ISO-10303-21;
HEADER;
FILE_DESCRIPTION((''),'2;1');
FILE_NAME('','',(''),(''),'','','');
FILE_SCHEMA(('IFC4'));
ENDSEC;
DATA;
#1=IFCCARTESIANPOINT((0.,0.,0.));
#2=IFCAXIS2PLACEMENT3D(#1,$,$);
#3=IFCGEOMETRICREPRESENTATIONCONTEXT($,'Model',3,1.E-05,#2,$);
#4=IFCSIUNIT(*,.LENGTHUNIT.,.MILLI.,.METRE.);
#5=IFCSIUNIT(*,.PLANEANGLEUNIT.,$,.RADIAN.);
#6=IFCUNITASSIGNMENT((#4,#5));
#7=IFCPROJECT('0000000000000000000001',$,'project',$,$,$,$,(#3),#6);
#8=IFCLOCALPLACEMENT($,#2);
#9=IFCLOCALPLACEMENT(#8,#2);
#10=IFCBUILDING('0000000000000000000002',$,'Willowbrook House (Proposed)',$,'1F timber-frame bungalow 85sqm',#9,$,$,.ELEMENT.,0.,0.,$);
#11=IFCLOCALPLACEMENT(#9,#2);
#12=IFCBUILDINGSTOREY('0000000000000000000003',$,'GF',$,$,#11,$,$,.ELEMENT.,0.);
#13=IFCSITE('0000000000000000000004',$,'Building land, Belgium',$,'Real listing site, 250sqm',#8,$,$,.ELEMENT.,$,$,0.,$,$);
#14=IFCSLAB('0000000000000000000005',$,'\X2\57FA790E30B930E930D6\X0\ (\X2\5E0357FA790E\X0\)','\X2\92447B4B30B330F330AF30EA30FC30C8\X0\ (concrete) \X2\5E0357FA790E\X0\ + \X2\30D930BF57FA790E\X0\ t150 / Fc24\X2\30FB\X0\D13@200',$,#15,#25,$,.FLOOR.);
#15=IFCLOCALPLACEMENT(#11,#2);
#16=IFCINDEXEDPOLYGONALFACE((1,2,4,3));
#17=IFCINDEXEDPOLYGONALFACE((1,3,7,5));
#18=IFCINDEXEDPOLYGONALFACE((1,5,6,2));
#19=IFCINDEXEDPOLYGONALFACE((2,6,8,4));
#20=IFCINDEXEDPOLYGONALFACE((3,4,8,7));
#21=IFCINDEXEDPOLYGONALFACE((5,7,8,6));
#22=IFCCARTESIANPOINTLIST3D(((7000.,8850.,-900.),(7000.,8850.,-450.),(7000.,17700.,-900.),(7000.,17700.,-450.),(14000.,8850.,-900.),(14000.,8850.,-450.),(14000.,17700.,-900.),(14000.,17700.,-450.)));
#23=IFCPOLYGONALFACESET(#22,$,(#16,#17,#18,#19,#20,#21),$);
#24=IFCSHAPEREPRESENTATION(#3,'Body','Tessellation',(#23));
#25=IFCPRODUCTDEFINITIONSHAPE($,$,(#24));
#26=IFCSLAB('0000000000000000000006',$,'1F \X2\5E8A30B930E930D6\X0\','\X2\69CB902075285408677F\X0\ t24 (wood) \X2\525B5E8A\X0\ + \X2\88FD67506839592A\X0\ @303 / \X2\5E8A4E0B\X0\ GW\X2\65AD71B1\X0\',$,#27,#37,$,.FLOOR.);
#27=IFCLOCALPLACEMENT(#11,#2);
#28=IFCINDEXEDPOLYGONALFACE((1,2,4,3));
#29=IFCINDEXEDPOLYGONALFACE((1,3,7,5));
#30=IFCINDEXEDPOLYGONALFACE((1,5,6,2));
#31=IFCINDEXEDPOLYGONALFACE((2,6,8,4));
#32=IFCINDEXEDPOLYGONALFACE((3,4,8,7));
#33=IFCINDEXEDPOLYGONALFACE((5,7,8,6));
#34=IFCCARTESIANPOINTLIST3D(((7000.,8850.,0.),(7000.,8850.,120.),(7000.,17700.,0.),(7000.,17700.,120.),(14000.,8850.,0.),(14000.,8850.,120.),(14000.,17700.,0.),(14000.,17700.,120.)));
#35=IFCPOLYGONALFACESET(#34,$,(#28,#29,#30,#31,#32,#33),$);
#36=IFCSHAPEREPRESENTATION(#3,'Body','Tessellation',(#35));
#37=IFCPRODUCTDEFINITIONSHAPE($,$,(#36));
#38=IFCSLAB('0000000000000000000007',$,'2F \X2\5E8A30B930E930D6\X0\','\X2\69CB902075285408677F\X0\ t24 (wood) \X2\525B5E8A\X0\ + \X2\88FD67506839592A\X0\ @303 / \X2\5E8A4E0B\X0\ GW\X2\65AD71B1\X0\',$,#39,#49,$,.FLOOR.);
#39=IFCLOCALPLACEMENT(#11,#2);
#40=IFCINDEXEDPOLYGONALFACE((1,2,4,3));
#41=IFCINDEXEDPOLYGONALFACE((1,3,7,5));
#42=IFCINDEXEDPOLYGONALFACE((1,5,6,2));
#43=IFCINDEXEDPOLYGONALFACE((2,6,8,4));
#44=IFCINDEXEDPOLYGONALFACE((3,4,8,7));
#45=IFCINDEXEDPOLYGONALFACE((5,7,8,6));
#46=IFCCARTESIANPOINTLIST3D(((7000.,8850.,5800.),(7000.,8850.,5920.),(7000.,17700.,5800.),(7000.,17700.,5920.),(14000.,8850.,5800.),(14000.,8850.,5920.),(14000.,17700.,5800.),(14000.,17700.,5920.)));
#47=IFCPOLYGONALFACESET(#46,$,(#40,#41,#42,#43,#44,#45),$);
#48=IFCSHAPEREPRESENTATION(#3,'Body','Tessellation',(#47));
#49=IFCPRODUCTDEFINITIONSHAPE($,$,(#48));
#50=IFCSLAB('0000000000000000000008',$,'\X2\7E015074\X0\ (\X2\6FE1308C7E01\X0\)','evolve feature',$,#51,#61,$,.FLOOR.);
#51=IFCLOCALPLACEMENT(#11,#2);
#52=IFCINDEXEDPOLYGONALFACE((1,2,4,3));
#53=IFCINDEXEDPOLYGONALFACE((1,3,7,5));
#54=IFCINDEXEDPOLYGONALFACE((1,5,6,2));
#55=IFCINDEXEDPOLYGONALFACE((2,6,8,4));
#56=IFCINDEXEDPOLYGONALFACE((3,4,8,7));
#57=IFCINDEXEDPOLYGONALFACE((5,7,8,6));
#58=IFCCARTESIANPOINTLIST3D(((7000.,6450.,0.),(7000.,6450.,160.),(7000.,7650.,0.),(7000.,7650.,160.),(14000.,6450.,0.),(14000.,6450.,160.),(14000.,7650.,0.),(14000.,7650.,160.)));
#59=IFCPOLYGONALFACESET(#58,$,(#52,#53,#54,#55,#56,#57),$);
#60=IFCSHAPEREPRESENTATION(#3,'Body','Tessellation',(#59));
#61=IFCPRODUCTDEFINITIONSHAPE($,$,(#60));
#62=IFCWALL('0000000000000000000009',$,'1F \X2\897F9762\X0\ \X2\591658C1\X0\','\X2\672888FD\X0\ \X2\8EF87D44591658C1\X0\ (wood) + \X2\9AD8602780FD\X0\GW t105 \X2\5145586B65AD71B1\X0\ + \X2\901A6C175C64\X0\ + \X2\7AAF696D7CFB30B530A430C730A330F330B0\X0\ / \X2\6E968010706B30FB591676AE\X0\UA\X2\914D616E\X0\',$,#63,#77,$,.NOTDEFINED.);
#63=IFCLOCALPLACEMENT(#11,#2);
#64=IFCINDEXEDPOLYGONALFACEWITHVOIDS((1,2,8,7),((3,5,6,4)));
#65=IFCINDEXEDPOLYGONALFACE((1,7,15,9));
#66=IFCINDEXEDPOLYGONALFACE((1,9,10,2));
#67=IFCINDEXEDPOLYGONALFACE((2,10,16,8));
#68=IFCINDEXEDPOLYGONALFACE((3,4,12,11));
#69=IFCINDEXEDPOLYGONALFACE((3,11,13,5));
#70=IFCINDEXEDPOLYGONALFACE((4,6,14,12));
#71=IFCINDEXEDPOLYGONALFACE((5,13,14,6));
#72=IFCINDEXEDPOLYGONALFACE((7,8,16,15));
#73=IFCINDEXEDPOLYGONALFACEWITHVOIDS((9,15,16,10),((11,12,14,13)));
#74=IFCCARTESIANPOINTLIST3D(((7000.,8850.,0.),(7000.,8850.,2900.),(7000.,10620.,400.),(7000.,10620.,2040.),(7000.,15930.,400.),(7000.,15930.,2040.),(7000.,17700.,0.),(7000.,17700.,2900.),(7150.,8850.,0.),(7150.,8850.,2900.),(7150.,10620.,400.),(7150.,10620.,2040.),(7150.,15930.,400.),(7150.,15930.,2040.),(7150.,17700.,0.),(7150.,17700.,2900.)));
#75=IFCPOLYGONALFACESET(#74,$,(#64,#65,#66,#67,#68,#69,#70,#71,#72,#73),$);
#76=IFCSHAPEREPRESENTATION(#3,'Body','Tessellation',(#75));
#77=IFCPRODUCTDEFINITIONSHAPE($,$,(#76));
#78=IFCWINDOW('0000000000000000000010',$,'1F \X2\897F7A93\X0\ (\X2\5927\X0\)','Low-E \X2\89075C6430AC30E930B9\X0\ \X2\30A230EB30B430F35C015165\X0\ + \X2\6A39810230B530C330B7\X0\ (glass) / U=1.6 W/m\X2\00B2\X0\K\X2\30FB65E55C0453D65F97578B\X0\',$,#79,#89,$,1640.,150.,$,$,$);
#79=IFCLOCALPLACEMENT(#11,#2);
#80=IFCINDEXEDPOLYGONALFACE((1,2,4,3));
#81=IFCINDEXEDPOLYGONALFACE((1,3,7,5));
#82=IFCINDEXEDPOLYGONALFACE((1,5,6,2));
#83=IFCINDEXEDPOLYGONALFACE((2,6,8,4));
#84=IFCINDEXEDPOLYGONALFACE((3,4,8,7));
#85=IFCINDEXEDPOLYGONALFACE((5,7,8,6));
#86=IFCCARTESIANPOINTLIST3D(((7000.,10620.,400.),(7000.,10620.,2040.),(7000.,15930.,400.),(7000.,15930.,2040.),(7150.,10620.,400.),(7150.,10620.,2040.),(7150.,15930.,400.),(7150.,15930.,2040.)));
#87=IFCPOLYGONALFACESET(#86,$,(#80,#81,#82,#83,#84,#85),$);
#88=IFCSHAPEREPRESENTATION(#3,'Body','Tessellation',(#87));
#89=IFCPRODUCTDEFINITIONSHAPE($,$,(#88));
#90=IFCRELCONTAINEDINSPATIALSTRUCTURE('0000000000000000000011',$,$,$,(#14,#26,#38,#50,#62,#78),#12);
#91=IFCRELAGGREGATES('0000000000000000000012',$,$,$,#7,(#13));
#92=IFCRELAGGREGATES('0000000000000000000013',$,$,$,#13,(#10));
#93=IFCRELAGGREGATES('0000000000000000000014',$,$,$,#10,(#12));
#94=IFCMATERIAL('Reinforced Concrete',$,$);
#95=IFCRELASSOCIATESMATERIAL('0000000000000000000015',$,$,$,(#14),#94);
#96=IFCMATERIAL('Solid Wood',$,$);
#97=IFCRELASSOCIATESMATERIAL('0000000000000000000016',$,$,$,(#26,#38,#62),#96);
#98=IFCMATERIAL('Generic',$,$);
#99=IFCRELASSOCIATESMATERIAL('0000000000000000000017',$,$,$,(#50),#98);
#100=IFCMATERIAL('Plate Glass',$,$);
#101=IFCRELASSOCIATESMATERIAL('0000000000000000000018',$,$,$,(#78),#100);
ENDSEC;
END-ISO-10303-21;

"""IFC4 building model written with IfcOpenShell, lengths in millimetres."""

from ifc_helpers import new_model, si_unit, frame, frame_2d, origin, place, context, project, spatial, rectangle, extrude, material, element, fill, save


model = new_model("IFC4")

# Units and contexts
model_context = context("Model", 3, precision=1e-05, world=origin())
ifc_project = project(units=[si_unit("LENGTHUNIT", "METRE", prefix="MILLI"), si_unit("PLANEANGLEUNIT", "RADIAN")], contexts=[model_context])

# Site, building, storey
site_placement = place(None, origin())
site = spatial("IfcSite", under=ifc_project, at=site_placement, Name="Building land, Belgium", ObjectType="Real listing site, 250sqm", CompositionType="ELEMENT", RefElevation=0.0)
building_placement = place(site_placement, origin())
building = spatial("IfcBuilding", under=site, at=building_placement, Name="Willowbrook House (Proposed)", ObjectType="1F timber-frame bungalow 85sqm", CompositionType="ELEMENT", ElevationOfRefHeight=0.0, ElevationOfTerrain=0.0)
storey_placement = place(building_placement, origin())
storey = spatial("IfcBuildingStorey", under=building, at=storey_placement, Name="GF", CompositionType="ELEMENT", Elevation=0.0)

# Slabs
ifc_material_1 = material(Name="Reinforced Concrete")
slab_1_placement = place(storey_placement, frame((3500.0, 4425.0, -450.0)))
element("IfcSlab", 1, at=slab_1_placement, inside=storey, material=ifc_material_1, Name="基礎スラブ (布基礎)", Description="鉄筋コンクリート (concrete) 布基礎 + ベタ基礎 t150 / Fc24・D13@200", PredefinedType="FLOOR", context=model_context, shape_type="SweptSolid", body=[
    extrude(rectangle(XDim=7000.0, YDim=8850.0, at=frame_2d((3500.0, 4425.0))), frame((3500.0, 4425.0, -450.0)), (0.0, 0.0, 1.0), 450.0),
])
ifc_material_2 = material(Name="Solid Wood")
slab_2_placement = place(storey_placement, frame((3500.0, 4425.0, 0.0)))
element("IfcSlab", 2, at=slab_2_placement, inside=storey, material=ifc_material_2, Name="1F 床スラブ", Description="構造用合板 t24 (wood) 剛床 + 製材根太 @303 / 床下 GW断熱", PredefinedType="FLOOR", context=model_context, shape_type="SweptSolid", body=[
    extrude(rectangle(XDim=7000.0, YDim=8850.0, at=frame_2d((3500.0, 4425.0))), frame((3500.0, 4425.0, 0.0)), (0.0, 0.0, 1.0), 120.0),
])
slab_3_placement = place(storey_placement, frame((3500.0, 4425.0, 2900.0)))
element("IfcSlab", 3, at=slab_3_placement, inside=storey, material=ifc_material_2, Name="2F 床スラブ", Description="構造用合板 t24 (wood) 剛床 + 製材根太 @303 / 床下 GW断熱", PredefinedType="FLOOR", context=model_context, shape_type="SweptSolid", body=[
    extrude(rectangle(XDim=7000.0, YDim=8850.0, at=frame_2d((3500.0, 4425.0))), frame((3500.0, 4425.0, 2900.0)), (0.0, 0.0, 1.0), 120.0),
])
ifc_material_3 = material(Name="Generic")
slab_4_placement = place(storey_placement, frame((3500.0, 3225.0, 0.0)))
element("IfcSlab", 4, at=slab_4_placement, inside=storey, material=ifc_material_3, Name="縁側 (濡れ縁)", Description="evolve feature", PredefinedType="FLOOR", context=model_context, shape_type="SweptSolid", body=[
    extrude(rectangle(XDim=7000.0, YDim=1200.0, at=frame_2d((3500.0, 600.0))), frame((3500.0, 3225.0, 0.0)), (0.0, 0.0, 1.0), 160.0),
])

# Shared definitions
ifc_material_4 = material(Name="Plate Glass")

# Wall, opening, window
wall_1_placement = place(storey_placement, frame((3500.0, 4425.0, 0.0)))
wall_1 = element("IfcWall", 5, at=wall_1_placement, inside=storey, material=ifc_material_2, Name="1F 西面 外壁", Description="木製 軸組外壁 (wood) + 高性能GW t105 充填断熱 + 通気層 + 窯業系サイディング / 準耐火・外皮UA配慮", PredefinedType="NOTDEFINED", context=model_context, shape_type="SweptSolid", body=[
    extrude(rectangle(XDim=150.0, YDim=8850.0, at=frame_2d((75.0, 4425.0))), frame((3500.0, 4425.0, 0.0)), (0.0, 0.0, 1.0), 2900.0),
])
opening_1_placement = place(storey_placement, frame((3500.0, 5310.0, 200.0)))
opening_1 = element("IfcOpeningElement", 6, at=opening_1_placement, cuts=wall_1, PredefinedType="NOTDEFINED", context=model_context, shape_type="SweptSolid", body=[
    extrude(rectangle(XDim=150.0, YDim=5310.0, at=frame_2d((75.0, 2655.0))), frame((3500.0, 5310.0, 200.0)), (0.0, 0.0, 1.0), 1640.0),
])
window_1_placement = place(storey_placement, frame((3500.0, 5310.0, 200.0)))
window_1 = element("IfcWindow", 7, at=window_1_placement, inside=storey, material=ifc_material_4, Name="1F 西窓 (大)", Description="Low-E 複層ガラス アルゴン封入 + 樹脂サッシ (glass) / U=1.6 W/m²K・日射取得型", OverallHeight=1640.0, OverallWidth=150.0, context=model_context, shape_type="SweptSolid", body=[
    extrude(rectangle(XDim=150.0, YDim=5310.0, at=frame_2d((75.0, 2655.0))), frame((3500.0, 5310.0, 200.0)), (0.0, 0.0, 1.0), 1640.0),
])
fill(opening_1, window_1)

save(model, "model.ifc")
